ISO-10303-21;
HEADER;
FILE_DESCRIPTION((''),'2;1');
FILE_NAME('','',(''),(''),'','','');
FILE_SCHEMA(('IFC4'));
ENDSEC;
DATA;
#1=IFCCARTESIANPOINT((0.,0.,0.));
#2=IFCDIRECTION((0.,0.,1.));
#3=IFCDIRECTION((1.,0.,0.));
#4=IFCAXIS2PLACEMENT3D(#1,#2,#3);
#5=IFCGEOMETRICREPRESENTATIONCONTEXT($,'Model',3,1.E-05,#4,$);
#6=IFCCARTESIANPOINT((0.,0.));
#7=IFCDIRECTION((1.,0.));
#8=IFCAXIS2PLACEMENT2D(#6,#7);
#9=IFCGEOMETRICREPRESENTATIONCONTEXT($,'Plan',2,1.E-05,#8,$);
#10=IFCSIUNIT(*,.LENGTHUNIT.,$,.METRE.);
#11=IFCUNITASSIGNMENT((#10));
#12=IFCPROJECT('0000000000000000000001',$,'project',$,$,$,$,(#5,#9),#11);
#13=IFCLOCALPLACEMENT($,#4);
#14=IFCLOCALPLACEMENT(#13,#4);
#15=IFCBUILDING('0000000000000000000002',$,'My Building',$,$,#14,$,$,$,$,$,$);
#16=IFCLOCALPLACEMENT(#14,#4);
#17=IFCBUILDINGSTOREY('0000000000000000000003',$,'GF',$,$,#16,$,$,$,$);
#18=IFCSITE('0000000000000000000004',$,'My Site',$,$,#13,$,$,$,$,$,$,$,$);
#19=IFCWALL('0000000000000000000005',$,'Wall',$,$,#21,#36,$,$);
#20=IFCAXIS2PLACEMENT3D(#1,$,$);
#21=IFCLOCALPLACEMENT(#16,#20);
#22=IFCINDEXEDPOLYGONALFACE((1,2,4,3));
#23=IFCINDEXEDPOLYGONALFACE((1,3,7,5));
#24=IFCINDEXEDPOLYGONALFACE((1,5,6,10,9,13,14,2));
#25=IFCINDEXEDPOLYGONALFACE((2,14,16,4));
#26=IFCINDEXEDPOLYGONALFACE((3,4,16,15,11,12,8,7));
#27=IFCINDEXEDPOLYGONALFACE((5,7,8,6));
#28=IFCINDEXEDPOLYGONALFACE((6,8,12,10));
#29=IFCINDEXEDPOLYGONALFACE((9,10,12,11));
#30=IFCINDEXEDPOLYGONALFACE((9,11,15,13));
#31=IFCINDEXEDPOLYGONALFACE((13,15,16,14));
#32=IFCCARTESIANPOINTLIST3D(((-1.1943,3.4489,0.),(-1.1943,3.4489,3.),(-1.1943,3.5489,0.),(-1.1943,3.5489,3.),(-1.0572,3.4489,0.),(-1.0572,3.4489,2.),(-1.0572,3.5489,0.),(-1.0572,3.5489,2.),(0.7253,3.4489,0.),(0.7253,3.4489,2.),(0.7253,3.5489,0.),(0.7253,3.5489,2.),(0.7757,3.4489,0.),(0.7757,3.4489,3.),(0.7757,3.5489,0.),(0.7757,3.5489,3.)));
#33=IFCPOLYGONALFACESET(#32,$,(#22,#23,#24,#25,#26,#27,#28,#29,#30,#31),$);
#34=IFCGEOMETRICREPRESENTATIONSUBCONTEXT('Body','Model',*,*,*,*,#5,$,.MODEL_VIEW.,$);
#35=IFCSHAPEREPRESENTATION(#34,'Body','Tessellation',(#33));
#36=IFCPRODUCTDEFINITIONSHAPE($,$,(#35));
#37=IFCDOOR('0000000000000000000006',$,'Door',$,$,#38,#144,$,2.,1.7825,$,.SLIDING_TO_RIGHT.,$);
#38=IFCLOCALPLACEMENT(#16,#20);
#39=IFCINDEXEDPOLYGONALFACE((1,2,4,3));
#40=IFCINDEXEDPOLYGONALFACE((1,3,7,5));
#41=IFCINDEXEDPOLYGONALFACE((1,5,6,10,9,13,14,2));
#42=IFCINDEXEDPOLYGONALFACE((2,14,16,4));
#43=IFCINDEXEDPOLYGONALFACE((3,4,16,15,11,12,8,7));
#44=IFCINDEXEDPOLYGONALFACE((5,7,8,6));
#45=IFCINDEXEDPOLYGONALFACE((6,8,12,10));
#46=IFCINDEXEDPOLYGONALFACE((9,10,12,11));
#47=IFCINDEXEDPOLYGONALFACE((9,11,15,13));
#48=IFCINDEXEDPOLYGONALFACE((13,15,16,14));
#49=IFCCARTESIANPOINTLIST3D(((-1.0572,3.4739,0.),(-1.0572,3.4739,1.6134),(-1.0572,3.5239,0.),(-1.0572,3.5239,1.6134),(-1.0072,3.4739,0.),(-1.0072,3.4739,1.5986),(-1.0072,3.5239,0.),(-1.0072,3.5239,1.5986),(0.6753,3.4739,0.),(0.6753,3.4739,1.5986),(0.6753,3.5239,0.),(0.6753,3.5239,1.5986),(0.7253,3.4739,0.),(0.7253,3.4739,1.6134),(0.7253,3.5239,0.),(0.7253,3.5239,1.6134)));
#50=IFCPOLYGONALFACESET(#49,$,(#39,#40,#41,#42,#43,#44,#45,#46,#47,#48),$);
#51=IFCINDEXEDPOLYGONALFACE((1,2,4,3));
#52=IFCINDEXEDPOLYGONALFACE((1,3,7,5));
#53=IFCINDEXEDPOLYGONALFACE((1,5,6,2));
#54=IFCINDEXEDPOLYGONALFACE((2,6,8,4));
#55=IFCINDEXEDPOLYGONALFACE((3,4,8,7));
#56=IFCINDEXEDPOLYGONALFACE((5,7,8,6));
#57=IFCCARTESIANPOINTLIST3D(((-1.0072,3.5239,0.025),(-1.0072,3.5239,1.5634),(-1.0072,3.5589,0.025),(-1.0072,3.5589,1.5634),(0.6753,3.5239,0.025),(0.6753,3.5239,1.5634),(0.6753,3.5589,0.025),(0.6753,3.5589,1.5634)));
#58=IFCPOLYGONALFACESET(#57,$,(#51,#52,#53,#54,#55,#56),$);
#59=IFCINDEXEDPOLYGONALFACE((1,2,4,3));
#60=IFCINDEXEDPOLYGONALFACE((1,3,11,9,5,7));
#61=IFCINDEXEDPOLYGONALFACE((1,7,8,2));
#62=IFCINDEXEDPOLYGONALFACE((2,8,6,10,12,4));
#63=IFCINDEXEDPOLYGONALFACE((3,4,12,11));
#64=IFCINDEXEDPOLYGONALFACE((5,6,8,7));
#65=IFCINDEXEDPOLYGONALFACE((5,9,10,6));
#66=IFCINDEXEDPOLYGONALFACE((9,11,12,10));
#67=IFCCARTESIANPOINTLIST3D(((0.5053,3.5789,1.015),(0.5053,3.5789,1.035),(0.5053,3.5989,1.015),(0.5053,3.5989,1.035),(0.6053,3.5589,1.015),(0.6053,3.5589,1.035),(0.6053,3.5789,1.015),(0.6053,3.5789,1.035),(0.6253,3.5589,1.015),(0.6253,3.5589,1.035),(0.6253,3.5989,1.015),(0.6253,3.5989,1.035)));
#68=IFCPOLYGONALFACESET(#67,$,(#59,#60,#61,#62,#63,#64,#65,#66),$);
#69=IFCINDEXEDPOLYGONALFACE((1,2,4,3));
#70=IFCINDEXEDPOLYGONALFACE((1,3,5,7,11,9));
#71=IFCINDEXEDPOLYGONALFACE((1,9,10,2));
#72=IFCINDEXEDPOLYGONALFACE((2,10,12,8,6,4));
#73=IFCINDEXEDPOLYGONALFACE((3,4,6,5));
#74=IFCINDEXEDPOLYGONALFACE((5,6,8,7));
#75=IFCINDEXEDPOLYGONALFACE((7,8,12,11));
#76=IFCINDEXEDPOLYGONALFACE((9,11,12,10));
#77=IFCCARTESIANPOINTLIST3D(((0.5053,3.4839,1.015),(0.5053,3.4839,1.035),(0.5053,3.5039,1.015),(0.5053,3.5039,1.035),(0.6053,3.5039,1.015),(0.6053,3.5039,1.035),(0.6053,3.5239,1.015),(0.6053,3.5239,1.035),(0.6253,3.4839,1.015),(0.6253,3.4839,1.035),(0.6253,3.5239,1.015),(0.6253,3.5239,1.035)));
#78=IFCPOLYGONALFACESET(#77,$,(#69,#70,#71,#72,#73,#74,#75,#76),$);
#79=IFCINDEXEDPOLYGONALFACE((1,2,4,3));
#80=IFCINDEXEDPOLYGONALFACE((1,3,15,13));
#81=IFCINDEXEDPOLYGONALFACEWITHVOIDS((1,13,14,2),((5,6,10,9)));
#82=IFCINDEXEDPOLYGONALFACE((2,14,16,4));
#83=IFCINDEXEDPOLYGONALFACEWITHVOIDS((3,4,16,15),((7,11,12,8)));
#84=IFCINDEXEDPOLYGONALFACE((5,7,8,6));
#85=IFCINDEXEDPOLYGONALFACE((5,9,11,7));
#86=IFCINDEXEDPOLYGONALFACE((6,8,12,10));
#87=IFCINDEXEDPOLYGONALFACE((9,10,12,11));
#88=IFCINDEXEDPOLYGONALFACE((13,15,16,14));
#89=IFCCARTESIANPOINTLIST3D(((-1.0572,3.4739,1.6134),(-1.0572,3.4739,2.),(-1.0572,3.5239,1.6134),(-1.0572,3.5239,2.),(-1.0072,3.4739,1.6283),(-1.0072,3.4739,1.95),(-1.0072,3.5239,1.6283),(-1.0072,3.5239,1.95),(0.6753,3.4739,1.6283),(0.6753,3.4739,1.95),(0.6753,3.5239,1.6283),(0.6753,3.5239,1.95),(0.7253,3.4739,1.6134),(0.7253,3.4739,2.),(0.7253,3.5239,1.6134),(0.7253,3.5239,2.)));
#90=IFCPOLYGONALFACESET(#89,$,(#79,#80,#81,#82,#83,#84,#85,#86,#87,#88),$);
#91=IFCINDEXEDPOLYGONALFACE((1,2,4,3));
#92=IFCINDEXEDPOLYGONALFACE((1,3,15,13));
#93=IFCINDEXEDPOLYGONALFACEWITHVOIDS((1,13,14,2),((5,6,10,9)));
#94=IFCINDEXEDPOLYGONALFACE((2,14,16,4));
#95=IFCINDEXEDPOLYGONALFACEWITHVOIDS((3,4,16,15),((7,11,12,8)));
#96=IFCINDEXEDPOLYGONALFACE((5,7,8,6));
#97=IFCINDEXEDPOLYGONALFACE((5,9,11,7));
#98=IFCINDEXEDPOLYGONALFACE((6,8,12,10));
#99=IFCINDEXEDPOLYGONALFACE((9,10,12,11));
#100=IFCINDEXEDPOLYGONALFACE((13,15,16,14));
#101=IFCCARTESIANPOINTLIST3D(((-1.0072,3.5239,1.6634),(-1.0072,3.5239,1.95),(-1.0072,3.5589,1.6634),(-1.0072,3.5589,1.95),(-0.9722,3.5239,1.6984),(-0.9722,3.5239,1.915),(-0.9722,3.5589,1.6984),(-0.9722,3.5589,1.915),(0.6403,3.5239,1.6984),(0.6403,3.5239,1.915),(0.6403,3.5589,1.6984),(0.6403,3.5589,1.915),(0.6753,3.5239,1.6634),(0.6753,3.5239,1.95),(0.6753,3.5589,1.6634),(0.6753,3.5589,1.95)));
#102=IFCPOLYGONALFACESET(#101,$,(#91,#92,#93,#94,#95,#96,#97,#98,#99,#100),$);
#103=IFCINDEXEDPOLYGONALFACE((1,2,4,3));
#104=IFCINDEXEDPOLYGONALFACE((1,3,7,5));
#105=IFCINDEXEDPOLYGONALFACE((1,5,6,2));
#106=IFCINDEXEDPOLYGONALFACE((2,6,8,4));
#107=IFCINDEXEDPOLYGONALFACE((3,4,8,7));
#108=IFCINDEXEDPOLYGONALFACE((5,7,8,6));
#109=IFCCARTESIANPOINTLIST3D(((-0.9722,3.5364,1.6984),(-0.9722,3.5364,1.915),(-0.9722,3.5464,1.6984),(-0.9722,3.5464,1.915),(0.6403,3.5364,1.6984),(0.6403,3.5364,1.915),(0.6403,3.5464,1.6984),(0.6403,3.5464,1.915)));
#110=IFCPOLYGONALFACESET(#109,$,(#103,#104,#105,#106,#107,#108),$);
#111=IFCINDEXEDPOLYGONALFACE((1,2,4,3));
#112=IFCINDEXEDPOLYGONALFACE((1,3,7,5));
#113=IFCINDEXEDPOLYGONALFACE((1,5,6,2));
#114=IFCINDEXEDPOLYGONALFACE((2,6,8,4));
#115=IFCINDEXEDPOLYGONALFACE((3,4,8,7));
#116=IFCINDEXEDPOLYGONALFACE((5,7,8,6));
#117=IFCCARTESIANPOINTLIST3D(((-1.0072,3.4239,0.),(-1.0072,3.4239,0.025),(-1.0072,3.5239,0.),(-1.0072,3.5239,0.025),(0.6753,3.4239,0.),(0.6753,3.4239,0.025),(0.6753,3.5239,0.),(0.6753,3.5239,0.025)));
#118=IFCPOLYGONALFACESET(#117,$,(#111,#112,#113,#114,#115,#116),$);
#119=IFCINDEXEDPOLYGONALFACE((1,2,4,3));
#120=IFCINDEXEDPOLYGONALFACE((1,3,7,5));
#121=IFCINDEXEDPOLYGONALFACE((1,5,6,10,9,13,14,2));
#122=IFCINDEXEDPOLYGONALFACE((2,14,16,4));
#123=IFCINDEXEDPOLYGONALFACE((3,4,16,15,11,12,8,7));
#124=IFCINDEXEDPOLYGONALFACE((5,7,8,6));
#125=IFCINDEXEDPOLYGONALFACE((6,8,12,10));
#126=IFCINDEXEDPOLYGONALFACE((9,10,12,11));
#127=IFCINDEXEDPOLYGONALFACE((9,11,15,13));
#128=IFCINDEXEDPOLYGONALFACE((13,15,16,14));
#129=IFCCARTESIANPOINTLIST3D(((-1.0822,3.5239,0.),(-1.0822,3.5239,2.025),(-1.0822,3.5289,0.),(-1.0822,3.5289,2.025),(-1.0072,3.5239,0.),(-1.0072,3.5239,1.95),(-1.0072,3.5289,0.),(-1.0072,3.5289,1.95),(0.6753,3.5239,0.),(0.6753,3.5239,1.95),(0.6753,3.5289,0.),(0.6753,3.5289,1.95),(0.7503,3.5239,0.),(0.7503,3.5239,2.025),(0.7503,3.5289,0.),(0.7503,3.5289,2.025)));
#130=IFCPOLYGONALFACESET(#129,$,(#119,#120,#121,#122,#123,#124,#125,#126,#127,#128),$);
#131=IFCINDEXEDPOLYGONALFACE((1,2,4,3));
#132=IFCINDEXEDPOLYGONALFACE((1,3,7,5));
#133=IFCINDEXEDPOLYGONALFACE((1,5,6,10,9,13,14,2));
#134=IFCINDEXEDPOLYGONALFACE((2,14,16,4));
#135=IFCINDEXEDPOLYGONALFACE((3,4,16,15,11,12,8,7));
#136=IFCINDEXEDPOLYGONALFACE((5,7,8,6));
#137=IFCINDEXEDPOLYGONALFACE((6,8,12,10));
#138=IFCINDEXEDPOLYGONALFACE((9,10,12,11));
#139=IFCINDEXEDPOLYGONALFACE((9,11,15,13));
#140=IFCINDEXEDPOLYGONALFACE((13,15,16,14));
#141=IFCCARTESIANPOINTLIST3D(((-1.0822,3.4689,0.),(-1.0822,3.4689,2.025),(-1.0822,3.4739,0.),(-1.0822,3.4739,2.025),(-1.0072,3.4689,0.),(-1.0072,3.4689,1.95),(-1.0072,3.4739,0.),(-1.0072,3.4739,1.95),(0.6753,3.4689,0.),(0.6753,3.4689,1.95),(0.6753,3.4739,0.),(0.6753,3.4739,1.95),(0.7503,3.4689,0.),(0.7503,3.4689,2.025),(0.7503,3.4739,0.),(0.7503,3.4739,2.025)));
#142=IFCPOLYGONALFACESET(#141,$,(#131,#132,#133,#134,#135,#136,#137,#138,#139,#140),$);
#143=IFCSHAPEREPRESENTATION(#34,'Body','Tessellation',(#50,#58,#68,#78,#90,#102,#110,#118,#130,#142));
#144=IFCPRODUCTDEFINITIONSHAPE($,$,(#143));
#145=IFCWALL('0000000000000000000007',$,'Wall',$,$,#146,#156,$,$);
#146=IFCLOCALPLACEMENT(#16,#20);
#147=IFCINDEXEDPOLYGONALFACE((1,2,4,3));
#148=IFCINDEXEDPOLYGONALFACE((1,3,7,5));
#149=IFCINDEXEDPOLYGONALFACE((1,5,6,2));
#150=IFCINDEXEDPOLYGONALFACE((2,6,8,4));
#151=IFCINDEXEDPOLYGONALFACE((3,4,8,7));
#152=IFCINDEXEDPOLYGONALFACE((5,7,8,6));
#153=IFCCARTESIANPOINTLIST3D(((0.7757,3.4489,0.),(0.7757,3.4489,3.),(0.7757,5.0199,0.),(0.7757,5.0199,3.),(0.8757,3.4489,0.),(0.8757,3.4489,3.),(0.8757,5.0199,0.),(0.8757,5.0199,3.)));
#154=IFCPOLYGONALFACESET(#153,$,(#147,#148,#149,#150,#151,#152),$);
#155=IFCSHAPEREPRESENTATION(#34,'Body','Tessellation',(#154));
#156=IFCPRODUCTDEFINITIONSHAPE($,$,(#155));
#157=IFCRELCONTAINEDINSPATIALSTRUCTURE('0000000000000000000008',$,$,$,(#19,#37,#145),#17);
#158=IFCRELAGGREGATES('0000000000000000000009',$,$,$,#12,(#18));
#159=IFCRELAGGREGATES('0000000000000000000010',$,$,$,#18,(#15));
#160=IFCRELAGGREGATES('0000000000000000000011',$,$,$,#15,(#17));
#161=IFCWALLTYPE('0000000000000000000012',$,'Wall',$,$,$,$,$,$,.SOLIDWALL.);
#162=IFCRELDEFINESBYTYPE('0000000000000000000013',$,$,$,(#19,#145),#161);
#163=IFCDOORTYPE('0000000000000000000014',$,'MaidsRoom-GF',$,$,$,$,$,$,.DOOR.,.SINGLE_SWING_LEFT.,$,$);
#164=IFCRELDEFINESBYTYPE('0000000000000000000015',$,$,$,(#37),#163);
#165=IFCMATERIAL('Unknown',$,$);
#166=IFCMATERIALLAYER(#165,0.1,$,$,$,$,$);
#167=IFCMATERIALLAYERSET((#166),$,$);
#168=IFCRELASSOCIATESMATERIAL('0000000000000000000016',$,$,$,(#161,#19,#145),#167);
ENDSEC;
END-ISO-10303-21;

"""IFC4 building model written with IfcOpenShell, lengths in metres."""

from ifc_helpers import new_model, entity, si_unit, frame, origin_with_axes, origin_2d_with_axis, place, context, subcontext, project, spatial, line, indexed_curve, outline, extrude, shape, source, transform, mapped, material, layer, layer_set, layer_usage, type_object, type_shapes, element, fill, save


model = new_model("IFC4")

# Units and contexts
model_context = context("Model", 3, precision=1e-05, world=origin_with_axes())
plan_context = context("Plan", 2, precision=1e-05, world=origin_2d_with_axis())
body_context_1 = subcontext(model_context, "Body", "Model", "MODEL_VIEW")
body_context_2 = subcontext(plan_context, "Body", "Plan", "PLAN_VIEW")
ifc_project = project(units=[si_unit("LENGTHUNIT", "METRE")], contexts=[model_context, plan_context])

# Site, building, storey
site_placement = place(None, origin_with_axes())
site = spatial("IfcSite", under=ifc_project, at=site_placement, Name="My Site")
building_placement = place(site_placement, origin_with_axes())
building = spatial("IfcBuilding", under=site, at=building_placement, Name="My Building")
storey_placement = place(building_placement, origin_with_axes())
storey = spatial("IfcBuildingStorey", under=building, at=storey_placement, Name="GF")

# Shared definitions
ifc_material_1 = material(Name="Unknown")

# Shared definitions
ifc_layer_1 = layer(ifc_material_1, 0.1)
ifc_layer_set_1 = layer_set([ifc_layer_1])
wall_type = type_object("IfcWallType", Name="Wall", PredefinedType="SOLIDWALL", material=ifc_layer_set_1)

# Wall, opening, door
ifc_layer_usage_1 = layer_usage(ifc_layer_set_1, "AXIS2", "POSITIVE", 0.0)
wall_1_placement = place(storey_placement, frame((0.7757, 3.5489, 0.0), z_axis=(0.0, 0.0, 1.0), x_axis=(-1.0, 0.0, 0.0)))
wall_1 = element("IfcWall", 1, at=wall_1_placement, inside=storey, type_object=wall_type, material=ifc_layer_usage_1, Name="Wall", context=body_context_1, shape_type="SweptSolid", body=[
    extrude(outline(indexed_curve([(0.0, 0.0), (0.0, 0.1), (1.97, 0.1), (1.97, 0.0)], segments=[line(1, 2, 3, 4, 1)])), origin_with_axes(), (0.0, 0.0, 1.0), 3.0),
])
shared_shape_1 = source(origin_with_axes(), body_context_1, "Body", "SweptSolid", [
    extrude(outline(indexed_curve([(0.0, 0.0), (1.7825, 0.0), (1.7825, 2.0), (0.0, 2.0)], segments=[line(1, 2, 3, 4, 1)])), frame((0.0, -0.6, 0.0), z_axis=(0.0, -1.0, 0.0), x_axis=(1.0, 0.0, 0.0)), (0.0, 0.0, -1.0), 1.2),
])
opening_1_placement = place(wall_1_placement, frame((0.0505, 0.025, 0.0), z_axis=(0.0, 0.0, 1.0), x_axis=(1.0, -0.000001, 0.0)))
opening_1 = element("IfcOpeningElement", 2, at=opening_1_placement, cuts=wall_1, PredefinedType="OPENING", context=body_context_1, shape_type="MappedRepresentation", body=[
    mapped(shared_shape_1, transform((0.0, 0.0, 0.0), x_axis=(1.0, 0.0, 0.0), y_axis=(0.0, 1.0, 0.0), z_axis=(0.0, 0.0, 1.0), scale=1.0)),
])
door_type_1 = type_object("IfcDoorType", Name="MaidsRoom-GF", OperationType="SINGLE_SWING_LEFT", PredefinedType="DOOR")
shared_shape_2 = source(origin_with_axes(), body_context_1, "Body", "SweptSolid", [
    extrude(outline(indexed_curve([(0.0, 0.0), (0.0, 1.6134), (1.7825, 1.6134), (1.7825, 0.0), (1.7325, 0.0), (1.7325, 1.5986), (0.05, 1.5986), (0.05, 0.0)], segments=[line(1, 2, 3, 4, 5, 6, 7, 8, 1)])), frame((0.0, 0.0, 0.0), z_axis=(0.0, -1.0, 0.0), x_axis=(1.0, 0.0, 0.0)), (0.0, 0.0, -1.0), 0.05),
    extrude(outline(indexed_curve([(0.0, 0.0), (1.6825, 0.0), (1.6825, 0.035), (0.0, 0.035)], segments=[line(1, 2, 3, 4, 1)])), frame((0.05, -0.035, 0.025), z_axis=(0.0, 0.0, 1.0), x_axis=(1.0, 0.0, 0.0)), (0.0, 0.0, 1.0), 1.5384),
    extrude(outline(indexed_curve([(0.0, 0.0), (0.0, -0.04), (0.12, -0.04), (0.12, -0.02), (0.02, -0.02), (0.02, 0.0)], segments=[line(1, 2, 3, 4, 5, 6, 1)])), frame((0.1, -0.035, 1.015), z_axis=(0.0, 0.0, 1.0), x_axis=(1.0, 0.0, 0.0)), (0.0, 0.0, 1.0), 0.02),
    extrude(outline(indexed_curve([(0.0, 0.0), (0.0, 0.04), (0.12, 0.04), (0.12, 0.02), (0.02, 0.02), (0.02, 0.0)], segments=[line(1, 2, 3, 4, 5, 6, 1)])), frame((0.1, 0.0, 1.015), z_axis=(0.0, 0.0, 1.0), x_axis=(1.0, 0.0, 0.0)), (0.0, 0.0, 1.0), 0.02),
    extrude(outline(indexed_curve([(0.0, 0.0), (1.7825, 0.0), (1.7825, 0.3866), (0.0, 0.3866)], segments=[line(1, 2, 3, 4, 1)]), holes=[indexed_curve([(0.05, 0.0148), (1.7325, 0.0148), (1.7325, 0.3366), (0.05, 0.3366)], segments=[line(1, 2, 3, 4, 1)])]), frame((0.0, 0.0, 1.6134), z_axis=(0.0, -1.0, 0.0), x_axis=(1.0, 0.0, 0.0)), (0.0, 0.0, -1.0), 0.05),
    extrude(outline(indexed_curve([(0.0, 0.0), (1.6825, 0.0), (1.6825, 0.2866), (0.0, 0.2866)], segments=[line(1, 2, 3, 4, 1)]), holes=[indexed_curve([(0.035, 0.035), (1.6475, 0.035), (1.6475, 0.2516), (0.035, 0.2516)], segments=[line(1, 2, 3, 4, 1)])]), frame((0.05, -0.035, 1.6634), z_axis=(0.0, -1.0, 0.0), x_axis=(1.0, 0.0, 0.0)), (0.0, 0.0, -1.0), 0.035),
    extrude(outline(indexed_curve([(0.035, 0.035), (1.6475, 0.035), (1.6475, 0.2516), (0.035, 0.2516)], segments=[line(1, 2, 3, 4, 1)])), frame((0.05, -0.0225, 1.6634), z_axis=(0.0, -1.0, 0.0), x_axis=(1.0, 0.0, 0.0)), (0.0, 0.0, -1.0), 0.01),
    extrude(outline(indexed_curve([(0.0, 0.0), (1.6825, 0.0), (1.6825, 0.1), (0.0, 0.1)], segments=[line(1, 2, 3, 4, 1)])), frame((0.05, 0.0, 0.0), z_axis=(0.0, 0.0, 1.0), x_axis=(1.0, 0.0, 0.0)), (0.0, 0.0, 1.0), 0.025),
    extrude(outline(indexed_curve([(0.0, 0.0), (0.0, 2.025), (1.8325, 2.025), (1.8325, 0.0), (1.7575, 0.0), (1.7575, 1.95), (0.075, 1.95), (0.075, 0.0)], segments=[line(1, 2, 3, 4, 5, 6, 7, 8, 1)])), frame((-0.025, -0.005, 0.0), z_axis=(0.0, -1.0, 0.0), x_axis=(1.0, 0.0, 0.0)), (0.0, 0.0, -1.0), 0.005),
    extrude(outline(indexed_curve([(0.0, 0.0), (0.0, 2.025), (1.8325, 2.025), (1.8325, 0.0), (1.7575, 0.0), (1.7575, 1.95), (0.075, 1.95), (0.075, 0.0)], segments=[line(1, 2, 3, 4, 5, 6, 7, 8, 1)])), frame((-0.025, 0.05, 0.0), z_axis=(0.0, -1.0, 0.0), x_axis=(1.0, 0.0, 0.0)), (0.0, 0.0, -1.0), 0.005),
])
shared_shape_3 = source(origin_with_axes(), body_context_2, "Body", "Curve2D", [
    entity("IfcIndexedPolyCurve", entity("IfcCartesianPointList2D", [[0.0, 0.0], [0.05, 0.0], [0.05, 0.05], [0.0, 0.05]]), [entity("IfcLineIndex", [1, 2, 3, 4, 1])]),
    entity("IfcIndexedPolyCurve", entity("IfcCartesianPointList2D", [[1.7825, 0.0], [1.7325, 0.0], [1.7325, 0.05], [1.7825, 0.05]]), [entity("IfcLineIndex", [1, 2, 3, 4, 1])]),
    entity("IfcIndexedPolyCurve", entity("IfcCartesianPointList2D", [[2.5737, -0.035], [0.8912, -0.035], [0.8912, 0.0], [2.5737, 0.0]]), [entity("IfcLineIndex", [1, 2, 3, 4, 1])]),
])
type_shapes(door_type_1, [shared_shape_2, shared_shape_3])
door_1_placement = place(opening_1_placement, frame((0.0, 0.0, 0.0), z_axis=(0.0, 0.0, 1.0), x_axis=(1.0, 0.0, 0.0)))
door_1 = element("IfcDoor", 3, at=door_1_placement, inside=storey, type_object=door_type_1, Name="Door", OperationType="SLIDING_TO_RIGHT", OverallHeight=2.0, OverallWidth=1.7825, shapes=[
    shape(body_context_1, "Body", "MappedRepresentation", [mapped(shared_shape_2, transform((0.0, 0.0, 0.0), x_axis=(1.0, 0.0, 0.0), y_axis=(0.0, 1.0, 0.0), z_axis=(0.0, 0.0, 1.0), scale=1.0))]),
    shape(body_context_2, "Body", "MappedRepresentation", [mapped(shared_shape_3, transform((0.0, 0.0, 0.0), x_axis=(1.0, 0.0, 0.0), y_axis=(0.0, 1.0, 0.0), z_axis=(0.0, 0.0, 1.0), scale=1.0))]),
])
fill(opening_1, door_1)

# Wall
ifc_layer_usage_2 = layer_usage(ifc_layer_set_1, "AXIS2", "POSITIVE", 0.0)
wall_2_placement = place(storey_placement, frame((0.7757, 5.0199, 0.0), z_axis=(0.0, 0.0, 1.0), x_axis=(0.0, -1.0, 0.0)))
element("IfcWall", 4, at=wall_2_placement, inside=storey, type_object=wall_type, material=ifc_layer_usage_2, Name="Wall", context=body_context_1, shape_type="SweptSolid", body=[
    extrude(outline(indexed_curve([(0.0, 0.0), (0.0, 0.1), (1.571, 0.1), (1.571, 0.0)], segments=[line(1, 2, 3, 4, 1)])), origin_with_axes(), (0.0, 0.0, 1.0), 3.0),
])

save(model, "model.ifc")
